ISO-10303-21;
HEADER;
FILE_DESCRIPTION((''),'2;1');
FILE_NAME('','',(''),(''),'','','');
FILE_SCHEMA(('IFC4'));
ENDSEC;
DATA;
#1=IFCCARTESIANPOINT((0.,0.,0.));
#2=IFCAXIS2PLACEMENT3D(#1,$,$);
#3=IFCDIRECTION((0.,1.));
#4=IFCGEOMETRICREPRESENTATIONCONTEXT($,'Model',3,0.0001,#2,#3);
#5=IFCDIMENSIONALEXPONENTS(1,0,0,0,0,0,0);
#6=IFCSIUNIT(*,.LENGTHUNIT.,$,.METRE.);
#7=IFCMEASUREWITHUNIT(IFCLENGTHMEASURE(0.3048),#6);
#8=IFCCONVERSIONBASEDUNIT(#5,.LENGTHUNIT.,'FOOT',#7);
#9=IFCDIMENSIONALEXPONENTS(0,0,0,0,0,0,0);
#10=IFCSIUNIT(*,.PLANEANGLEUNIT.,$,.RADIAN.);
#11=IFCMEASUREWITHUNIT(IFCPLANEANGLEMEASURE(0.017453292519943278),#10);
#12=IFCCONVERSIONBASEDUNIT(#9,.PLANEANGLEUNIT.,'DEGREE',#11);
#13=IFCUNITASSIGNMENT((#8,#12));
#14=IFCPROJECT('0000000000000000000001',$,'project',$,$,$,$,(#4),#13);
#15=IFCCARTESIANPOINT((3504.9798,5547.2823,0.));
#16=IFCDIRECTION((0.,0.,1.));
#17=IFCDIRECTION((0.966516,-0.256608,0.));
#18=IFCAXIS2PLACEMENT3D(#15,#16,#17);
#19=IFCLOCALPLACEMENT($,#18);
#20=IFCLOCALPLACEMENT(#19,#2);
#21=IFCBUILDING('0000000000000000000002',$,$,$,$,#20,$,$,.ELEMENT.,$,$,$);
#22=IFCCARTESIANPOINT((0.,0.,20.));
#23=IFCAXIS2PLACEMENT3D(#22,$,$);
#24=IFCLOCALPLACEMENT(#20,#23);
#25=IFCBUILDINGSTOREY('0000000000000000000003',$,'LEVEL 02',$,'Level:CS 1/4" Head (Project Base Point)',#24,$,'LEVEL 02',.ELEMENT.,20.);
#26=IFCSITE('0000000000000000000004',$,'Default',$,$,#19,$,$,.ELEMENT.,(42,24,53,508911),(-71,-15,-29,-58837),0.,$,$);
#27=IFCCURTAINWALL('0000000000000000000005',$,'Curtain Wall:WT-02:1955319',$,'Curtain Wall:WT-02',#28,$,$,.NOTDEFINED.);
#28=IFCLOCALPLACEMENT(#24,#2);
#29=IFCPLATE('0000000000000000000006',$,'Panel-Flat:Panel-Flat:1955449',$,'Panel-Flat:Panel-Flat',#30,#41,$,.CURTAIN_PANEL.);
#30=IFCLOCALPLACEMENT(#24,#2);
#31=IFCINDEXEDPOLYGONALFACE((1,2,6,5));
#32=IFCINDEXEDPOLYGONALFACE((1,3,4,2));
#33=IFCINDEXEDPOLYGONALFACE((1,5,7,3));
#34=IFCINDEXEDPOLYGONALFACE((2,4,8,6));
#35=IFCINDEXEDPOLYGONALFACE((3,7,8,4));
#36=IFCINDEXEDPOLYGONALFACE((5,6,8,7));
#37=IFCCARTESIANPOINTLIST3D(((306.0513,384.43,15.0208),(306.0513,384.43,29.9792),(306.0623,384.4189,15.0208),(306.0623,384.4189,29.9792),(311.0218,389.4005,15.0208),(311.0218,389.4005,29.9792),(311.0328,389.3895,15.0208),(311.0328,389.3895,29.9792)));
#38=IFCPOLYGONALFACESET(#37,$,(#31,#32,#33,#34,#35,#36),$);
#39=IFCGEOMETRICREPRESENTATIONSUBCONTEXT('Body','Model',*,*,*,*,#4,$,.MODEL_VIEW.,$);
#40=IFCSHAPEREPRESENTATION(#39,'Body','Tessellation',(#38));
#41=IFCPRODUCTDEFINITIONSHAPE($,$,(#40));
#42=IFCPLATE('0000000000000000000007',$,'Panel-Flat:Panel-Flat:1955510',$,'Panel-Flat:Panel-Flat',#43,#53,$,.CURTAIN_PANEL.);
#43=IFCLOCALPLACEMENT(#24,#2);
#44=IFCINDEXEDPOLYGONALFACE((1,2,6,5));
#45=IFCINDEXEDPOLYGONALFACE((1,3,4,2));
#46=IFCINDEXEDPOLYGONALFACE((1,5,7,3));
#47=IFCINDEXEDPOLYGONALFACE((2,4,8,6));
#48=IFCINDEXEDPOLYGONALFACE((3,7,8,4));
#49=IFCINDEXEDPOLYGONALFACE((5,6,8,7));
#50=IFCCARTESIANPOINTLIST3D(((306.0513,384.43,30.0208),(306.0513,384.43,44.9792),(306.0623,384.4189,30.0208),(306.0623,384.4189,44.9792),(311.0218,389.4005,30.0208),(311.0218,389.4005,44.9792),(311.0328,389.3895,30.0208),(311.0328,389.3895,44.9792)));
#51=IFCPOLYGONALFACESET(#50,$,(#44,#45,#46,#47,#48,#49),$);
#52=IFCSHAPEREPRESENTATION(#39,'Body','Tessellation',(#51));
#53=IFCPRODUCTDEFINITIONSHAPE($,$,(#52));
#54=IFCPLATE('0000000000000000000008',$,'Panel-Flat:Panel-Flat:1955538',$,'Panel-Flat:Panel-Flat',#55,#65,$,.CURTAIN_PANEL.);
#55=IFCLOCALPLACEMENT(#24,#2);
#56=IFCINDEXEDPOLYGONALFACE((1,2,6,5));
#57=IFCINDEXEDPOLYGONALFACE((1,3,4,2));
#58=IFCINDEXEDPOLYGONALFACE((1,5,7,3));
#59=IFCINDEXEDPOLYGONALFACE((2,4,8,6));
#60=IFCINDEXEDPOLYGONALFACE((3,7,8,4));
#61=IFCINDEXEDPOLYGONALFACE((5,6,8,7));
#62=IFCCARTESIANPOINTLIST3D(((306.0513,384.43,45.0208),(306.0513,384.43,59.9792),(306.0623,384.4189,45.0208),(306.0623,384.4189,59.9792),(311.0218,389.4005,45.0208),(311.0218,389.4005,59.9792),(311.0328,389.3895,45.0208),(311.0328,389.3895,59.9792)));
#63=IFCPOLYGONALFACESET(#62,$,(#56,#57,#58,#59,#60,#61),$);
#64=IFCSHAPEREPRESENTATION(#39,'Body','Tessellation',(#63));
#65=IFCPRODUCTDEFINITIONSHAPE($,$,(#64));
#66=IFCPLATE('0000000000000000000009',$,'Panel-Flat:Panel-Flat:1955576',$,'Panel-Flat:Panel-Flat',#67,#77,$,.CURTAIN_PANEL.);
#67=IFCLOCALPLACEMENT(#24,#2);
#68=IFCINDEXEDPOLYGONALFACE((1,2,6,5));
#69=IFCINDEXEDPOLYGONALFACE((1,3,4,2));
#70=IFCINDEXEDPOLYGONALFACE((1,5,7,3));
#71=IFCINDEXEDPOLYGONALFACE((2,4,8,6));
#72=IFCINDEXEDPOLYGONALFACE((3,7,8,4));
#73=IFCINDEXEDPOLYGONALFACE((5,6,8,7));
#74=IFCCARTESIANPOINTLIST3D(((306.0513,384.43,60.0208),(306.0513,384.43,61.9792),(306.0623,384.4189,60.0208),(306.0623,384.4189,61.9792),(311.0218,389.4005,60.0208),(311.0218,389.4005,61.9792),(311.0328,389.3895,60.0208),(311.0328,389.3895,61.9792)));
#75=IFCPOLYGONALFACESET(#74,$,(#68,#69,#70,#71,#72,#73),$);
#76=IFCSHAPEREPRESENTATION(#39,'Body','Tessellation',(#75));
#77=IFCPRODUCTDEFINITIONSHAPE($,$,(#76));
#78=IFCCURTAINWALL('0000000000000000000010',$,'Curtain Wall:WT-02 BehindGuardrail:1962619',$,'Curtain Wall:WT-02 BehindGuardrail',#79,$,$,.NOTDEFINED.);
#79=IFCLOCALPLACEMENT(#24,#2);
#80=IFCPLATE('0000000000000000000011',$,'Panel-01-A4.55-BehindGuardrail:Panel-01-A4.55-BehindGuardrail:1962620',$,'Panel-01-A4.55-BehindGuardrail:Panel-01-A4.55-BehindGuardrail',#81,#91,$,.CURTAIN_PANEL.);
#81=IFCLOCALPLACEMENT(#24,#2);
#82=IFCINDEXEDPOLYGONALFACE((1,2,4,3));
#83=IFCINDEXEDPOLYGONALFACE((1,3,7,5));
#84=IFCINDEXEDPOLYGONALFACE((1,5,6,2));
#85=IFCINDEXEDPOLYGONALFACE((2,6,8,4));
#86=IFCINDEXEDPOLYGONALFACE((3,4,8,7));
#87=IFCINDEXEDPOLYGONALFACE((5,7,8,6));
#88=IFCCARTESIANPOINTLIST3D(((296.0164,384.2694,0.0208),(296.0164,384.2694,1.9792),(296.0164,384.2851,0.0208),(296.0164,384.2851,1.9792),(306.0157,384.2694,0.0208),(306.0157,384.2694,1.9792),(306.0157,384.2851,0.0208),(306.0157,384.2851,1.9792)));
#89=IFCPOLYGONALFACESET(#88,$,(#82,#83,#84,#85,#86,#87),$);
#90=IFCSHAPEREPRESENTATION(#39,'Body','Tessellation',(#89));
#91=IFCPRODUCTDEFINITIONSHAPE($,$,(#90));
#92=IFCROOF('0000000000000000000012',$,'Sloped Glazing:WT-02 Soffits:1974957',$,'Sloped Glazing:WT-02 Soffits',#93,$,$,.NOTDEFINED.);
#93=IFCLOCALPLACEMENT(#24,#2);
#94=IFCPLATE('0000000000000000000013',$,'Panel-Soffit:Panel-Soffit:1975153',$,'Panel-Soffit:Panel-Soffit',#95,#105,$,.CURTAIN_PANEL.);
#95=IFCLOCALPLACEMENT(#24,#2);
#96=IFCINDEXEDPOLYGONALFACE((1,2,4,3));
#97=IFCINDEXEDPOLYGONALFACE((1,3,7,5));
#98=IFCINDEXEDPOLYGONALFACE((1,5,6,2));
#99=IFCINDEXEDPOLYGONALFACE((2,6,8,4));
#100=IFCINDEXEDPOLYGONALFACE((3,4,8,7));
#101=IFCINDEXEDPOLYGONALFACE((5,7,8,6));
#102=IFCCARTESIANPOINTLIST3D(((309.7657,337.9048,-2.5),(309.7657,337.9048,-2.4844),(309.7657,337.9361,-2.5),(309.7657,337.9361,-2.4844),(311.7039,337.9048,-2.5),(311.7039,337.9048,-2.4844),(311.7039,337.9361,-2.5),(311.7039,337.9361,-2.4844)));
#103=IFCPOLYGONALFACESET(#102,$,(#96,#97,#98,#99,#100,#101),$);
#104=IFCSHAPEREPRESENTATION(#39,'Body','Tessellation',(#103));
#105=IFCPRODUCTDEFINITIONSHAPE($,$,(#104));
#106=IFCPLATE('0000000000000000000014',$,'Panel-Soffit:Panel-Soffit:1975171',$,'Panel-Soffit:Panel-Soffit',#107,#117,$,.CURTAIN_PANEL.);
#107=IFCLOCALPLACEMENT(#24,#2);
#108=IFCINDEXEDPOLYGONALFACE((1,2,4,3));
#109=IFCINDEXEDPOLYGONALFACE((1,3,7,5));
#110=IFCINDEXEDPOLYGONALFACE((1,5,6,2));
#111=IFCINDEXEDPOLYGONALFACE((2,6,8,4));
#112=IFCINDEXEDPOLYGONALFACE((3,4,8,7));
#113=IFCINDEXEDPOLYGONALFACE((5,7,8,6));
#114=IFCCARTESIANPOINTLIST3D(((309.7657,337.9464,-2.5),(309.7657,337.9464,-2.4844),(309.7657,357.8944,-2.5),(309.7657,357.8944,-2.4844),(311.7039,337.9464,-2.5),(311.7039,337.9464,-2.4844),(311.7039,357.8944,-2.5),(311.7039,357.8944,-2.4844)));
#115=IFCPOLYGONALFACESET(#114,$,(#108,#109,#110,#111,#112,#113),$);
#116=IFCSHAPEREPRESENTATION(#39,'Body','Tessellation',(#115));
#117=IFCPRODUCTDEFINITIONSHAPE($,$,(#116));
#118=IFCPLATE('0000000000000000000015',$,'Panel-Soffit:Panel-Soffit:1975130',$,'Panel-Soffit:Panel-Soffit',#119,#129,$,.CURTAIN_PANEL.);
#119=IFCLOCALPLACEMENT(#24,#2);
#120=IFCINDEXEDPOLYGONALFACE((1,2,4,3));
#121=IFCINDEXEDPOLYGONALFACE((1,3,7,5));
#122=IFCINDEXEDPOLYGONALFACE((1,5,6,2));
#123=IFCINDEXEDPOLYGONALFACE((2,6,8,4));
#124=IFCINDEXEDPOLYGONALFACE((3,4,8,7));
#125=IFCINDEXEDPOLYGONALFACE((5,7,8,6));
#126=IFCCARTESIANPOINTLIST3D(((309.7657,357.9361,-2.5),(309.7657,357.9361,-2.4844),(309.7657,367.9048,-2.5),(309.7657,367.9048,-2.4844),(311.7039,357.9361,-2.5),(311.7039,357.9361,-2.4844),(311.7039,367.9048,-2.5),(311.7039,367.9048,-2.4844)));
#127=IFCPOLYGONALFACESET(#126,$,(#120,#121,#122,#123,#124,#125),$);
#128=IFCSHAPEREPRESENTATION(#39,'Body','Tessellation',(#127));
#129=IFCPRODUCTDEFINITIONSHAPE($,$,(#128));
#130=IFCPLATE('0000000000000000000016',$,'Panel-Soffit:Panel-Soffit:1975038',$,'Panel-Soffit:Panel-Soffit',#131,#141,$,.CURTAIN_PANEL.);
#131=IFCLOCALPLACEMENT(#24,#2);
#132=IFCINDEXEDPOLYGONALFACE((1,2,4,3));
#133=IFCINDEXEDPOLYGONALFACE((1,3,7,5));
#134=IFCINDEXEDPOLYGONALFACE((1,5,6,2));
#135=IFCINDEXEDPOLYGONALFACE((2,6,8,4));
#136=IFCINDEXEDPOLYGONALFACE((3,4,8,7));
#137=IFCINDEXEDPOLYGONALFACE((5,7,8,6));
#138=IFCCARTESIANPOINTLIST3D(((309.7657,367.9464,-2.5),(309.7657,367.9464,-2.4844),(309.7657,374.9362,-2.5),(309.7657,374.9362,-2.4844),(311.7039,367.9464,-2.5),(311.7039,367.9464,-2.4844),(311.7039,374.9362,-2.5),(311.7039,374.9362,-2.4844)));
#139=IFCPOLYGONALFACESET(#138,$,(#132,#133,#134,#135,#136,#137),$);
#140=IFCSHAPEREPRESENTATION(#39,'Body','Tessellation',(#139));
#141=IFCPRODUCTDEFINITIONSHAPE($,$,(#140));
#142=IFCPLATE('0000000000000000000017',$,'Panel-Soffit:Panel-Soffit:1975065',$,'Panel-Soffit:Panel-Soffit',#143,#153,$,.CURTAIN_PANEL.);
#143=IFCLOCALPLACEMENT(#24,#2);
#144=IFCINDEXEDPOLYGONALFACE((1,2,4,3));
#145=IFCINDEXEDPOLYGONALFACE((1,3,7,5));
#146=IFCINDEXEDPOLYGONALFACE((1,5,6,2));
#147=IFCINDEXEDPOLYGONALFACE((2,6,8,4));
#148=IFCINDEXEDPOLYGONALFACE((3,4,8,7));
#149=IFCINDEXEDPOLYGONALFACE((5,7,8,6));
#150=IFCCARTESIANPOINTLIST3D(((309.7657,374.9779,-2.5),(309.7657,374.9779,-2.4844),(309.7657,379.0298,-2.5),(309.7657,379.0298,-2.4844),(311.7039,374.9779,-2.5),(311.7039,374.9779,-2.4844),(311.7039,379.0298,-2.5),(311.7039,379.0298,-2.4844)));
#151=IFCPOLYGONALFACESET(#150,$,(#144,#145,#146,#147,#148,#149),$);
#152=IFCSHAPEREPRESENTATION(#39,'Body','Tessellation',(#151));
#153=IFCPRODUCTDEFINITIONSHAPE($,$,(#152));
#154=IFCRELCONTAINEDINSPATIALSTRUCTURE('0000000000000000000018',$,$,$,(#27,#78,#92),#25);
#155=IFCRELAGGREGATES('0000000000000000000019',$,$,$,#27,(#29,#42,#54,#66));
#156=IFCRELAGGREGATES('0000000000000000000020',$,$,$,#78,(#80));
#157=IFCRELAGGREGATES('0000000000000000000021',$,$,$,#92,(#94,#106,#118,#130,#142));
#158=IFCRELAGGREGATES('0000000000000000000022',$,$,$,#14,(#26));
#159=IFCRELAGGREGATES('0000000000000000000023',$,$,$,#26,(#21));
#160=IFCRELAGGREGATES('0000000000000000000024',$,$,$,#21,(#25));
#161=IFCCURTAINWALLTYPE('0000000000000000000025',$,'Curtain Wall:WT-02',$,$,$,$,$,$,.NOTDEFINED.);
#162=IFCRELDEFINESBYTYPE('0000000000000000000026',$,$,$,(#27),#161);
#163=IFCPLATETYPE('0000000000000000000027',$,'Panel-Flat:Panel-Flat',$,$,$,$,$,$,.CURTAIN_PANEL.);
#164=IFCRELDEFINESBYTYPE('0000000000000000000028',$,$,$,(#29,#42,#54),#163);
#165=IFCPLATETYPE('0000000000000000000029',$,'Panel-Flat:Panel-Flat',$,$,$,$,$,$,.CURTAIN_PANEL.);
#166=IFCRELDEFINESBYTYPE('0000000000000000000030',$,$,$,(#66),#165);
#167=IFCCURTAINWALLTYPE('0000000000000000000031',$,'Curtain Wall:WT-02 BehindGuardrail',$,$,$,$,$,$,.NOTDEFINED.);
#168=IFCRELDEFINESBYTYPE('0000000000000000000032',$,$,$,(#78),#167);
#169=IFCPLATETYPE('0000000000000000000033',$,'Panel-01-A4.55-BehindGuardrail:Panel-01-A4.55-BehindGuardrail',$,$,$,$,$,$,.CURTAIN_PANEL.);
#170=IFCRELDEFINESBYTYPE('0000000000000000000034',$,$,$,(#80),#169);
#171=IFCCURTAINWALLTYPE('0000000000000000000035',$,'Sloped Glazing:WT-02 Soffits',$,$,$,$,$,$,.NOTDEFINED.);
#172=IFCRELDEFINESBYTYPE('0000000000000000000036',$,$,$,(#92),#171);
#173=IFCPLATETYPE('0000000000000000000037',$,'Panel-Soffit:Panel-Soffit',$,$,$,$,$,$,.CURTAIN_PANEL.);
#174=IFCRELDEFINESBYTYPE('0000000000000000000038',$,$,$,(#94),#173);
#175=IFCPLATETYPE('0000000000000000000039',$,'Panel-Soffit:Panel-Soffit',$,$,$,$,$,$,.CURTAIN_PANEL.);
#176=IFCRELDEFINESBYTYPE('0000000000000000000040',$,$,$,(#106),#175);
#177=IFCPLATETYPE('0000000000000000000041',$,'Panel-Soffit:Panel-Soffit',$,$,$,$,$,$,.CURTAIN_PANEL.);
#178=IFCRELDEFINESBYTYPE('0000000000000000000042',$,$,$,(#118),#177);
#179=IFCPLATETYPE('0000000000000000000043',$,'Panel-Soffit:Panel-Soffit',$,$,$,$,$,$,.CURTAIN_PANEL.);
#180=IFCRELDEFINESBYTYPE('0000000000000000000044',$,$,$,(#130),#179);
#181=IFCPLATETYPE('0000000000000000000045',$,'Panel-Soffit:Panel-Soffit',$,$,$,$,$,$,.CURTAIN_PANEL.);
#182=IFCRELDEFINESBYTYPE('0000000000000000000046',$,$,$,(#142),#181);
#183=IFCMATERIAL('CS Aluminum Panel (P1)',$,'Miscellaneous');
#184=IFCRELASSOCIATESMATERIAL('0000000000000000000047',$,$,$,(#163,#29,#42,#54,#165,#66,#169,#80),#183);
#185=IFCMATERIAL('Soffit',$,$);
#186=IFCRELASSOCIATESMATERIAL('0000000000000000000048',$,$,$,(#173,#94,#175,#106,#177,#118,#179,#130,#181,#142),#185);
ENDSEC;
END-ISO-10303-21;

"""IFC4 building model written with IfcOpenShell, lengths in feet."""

from ifc_helpers import new_model, entity, si_unit, converted_unit, direction, frame, origin, place, context, subcontext, project, spatial, indexed_curve, outline, extrude, source, transform, mapped, material, type_object, type_shapes, element, aggregate, save


model = new_model("IFC4")

# Units and contexts
model_context = context("Model", 3, precision=0.0001, world=origin(), true_north=direction((0.0, 1.0)))
body_context = subcontext(model_context, "Body", "Model", "MODEL_VIEW")
ifc_project = project(units=[converted_unit("LENGTHUNIT", "FOOT", entity("IfcLengthMeasure", 0.3048), si_unit("LENGTHUNIT", "METRE"), dimensions=[1, 0, 0, 0, 0, 0, 0]), converted_unit("PLANEANGLEUNIT", "DEGREE", entity("IfcPlaneAngleMeasure", 0.017453292519943278), si_unit("PLANEANGLEUNIT", "RADIAN"), dimensions=[0, 0, 0, 0, 0, 0, 0])], contexts=[model_context])

# Site, building, storey
site_placement = place(None, frame((3504.9798, 5547.2823, 0.0), z_axis=(0.0, 0.0, 1.0), x_axis=(0.966516, -0.256608, 0.0)))
site = spatial("IfcSite", under=ifc_project, at=site_placement, Name="Default", CompositionType="ELEMENT", RefLatitude=(42, 24, 53, 508911), RefLongitude=(-71, -15, -29, -58837), RefElevation=0.0)
building_placement = place(site_placement, origin())
building = spatial("IfcBuilding", under=site, at=building_placement, CompositionType="ELEMENT")
storey_placement = place(building_placement, frame((0.0, 0.0, 20.0)))
storey = spatial("IfcBuildingStorey", under=building, at=storey_placement, Name="LEVEL 02", ObjectType="Level:CS 1/4\" Head (Project Base Point)", LongName="LEVEL 02", CompositionType="ELEMENT", Elevation=20.0)

# Shared definitions
curtain_wall_type_1 = type_object("IfcCurtainWallType", Name="Curtain Wall:WT-02", PredefinedType="NOTDEFINED")
ifc_material_1 = material(Name="CS Aluminum Panel (P1)", Category="Miscellaneous")

# Shared definitions
curtain_wall_type_2 = type_object("IfcCurtainWallType", Name="Sloped Glazing:WT-02 Soffits", PredefinedType="NOTDEFINED")
ifc_material_2 = material(Name="Soffit")

# Curtain wall, plates
curtain_wall_1_placement = place(storey_placement, frame((0.0, 0.0, -20.0)))
curtain_wall_1 = element("IfcCurtainWall", 1, at=curtain_wall_1_placement, inside=storey, type_object=curtain_wall_type_1, Name="Curtain Wall:WT-02:1955319", ObjectType="Curtain Wall:WT-02", PredefinedType="NOTDEFINED")
plate_type_1 = type_object("IfcPlateType", Name="Panel-Flat:Panel-Flat", PredefinedType="CURTAIN_PANEL", material=ifc_material_1)
shared_shape_1 = source(origin(), body_context, "Body", "SweptSolid", [
    extrude(outline(indexed_curve([(-0.0078, -3.5147), (0.0078, -3.5147), (0.0078, 3.5147), (-0.0078, 3.5147), (-0.0078, -3.5147)], self_intersect=False)), frame((3.5147, 0.0078, 0.0), z_axis=(0.0, 0.0, 1.0), x_axis=(0.0, -1.0, 0.0)), (0.0, 0.0, 1.0), 14.9583),
])
type_shapes(plate_type_1, [shared_shape_1])
plate_1_placement = place(curtain_wall_1_placement, frame((306.0623, 384.4189, 35.0208), z_axis=(0.0, 0.0, 1.0), x_axis=(0.707107, 0.707107, 0.0)))
plate_1 = element("IfcPlate", 2, at=plate_1_placement, type_object=plate_type_1, material=ifc_material_1, Name="Panel-Flat:Panel-Flat:1955449", ObjectType="Panel-Flat:Panel-Flat", PredefinedType="CURTAIN_PANEL", context=body_context, shape_type="MappedRepresentation", body=[
    mapped(shared_shape_1, transform((0.0, 0.0, 0.0), scale=1.0)),
])
plate_2_placement = place(curtain_wall_1_placement, frame((306.0623, 384.4189, 50.0208), z_axis=(0.0, 0.0, 1.0), x_axis=(0.707107, 0.707107, 0.0)))
plate_2 = element("IfcPlate", 3, at=plate_2_placement, type_object=plate_type_1, material=ifc_material_1, Name="Panel-Flat:Panel-Flat:1955510", ObjectType="Panel-Flat:Panel-Flat", PredefinedType="CURTAIN_PANEL", context=body_context, shape_type="MappedRepresentation", body=[
    mapped(shared_shape_1, transform((0.0, 0.0, 0.0), scale=1.0)),
])
plate_3_placement = place(curtain_wall_1_placement, frame((306.0623, 384.4189, 65.0208), z_axis=(0.0, 0.0, 1.0), x_axis=(0.707107, 0.707107, 0.0)))
plate_3 = element("IfcPlate", 4, at=plate_3_placement, type_object=plate_type_1, material=ifc_material_1, Name="Panel-Flat:Panel-Flat:1955538", ObjectType="Panel-Flat:Panel-Flat", PredefinedType="CURTAIN_PANEL", context=body_context, shape_type="MappedRepresentation", body=[
    mapped(shared_shape_1, transform((0.0, 0.0, 0.0), scale=1.0)),
])
plate_type_2 = type_object("IfcPlateType", Name="Panel-Flat:Panel-Flat", PredefinedType="CURTAIN_PANEL", material=ifc_material_1)
shared_shape_2 = source(origin(), body_context, "Body", "SweptSolid", [
    extrude(outline(indexed_curve([(-0.0078, -3.5147), (0.0078, -3.5147), (0.0078, 3.5147), (-0.0078, 3.5147), (-0.0078, -3.5147)], self_intersect=False)), frame((3.5147, 0.0078, 0.0), z_axis=(0.0, 0.0, 1.0), x_axis=(0.0, -1.0, 0.0)), (0.0, 0.0, 1.0), 1.9583),
])
type_shapes(plate_type_2, [shared_shape_2])
plate_4_placement = place(curtain_wall_1_placement, frame((306.0623, 384.4189, 80.0208), z_axis=(0.0, 0.0, 1.0), x_axis=(0.707107, 0.707107, 0.0)))
plate_4 = element("IfcPlate", 5, at=plate_4_placement, type_object=plate_type_2, material=ifc_material_1, Name="Panel-Flat:Panel-Flat:1955576", ObjectType="Panel-Flat:Panel-Flat", PredefinedType="CURTAIN_PANEL", context=body_context, shape_type="MappedRepresentation", body=[
    mapped(shared_shape_2, transform((0.0, 0.0, 0.0), scale=1.0)),
])
aggregate(curtain_wall_1, [plate_1, plate_2, plate_3, plate_4])

# Curtain wall, plate
curtain_wall_type_3 = type_object("IfcCurtainWallType", Name="Curtain Wall:WT-02 BehindGuardrail", PredefinedType="NOTDEFINED")
curtain_wall_2_placement = place(storey_placement, frame((0.0, 0.0, -20.0)))
curtain_wall_2 = element("IfcCurtainWall", 6, at=curtain_wall_2_placement, inside=storey, type_object=curtain_wall_type_3, Name="Curtain Wall:WT-02 BehindGuardrail:1962619", ObjectType="Curtain Wall:WT-02 BehindGuardrail", PredefinedType="NOTDEFINED")
plate_type_3 = type_object("IfcPlateType", Name="Panel-01-A4.55-BehindGuardrail:Panel-01-A4.55-BehindGuardrail", PredefinedType="CURTAIN_PANEL", material=ifc_material_1)
shared_shape_3 = source(origin(), body_context, "Body", "SweptSolid", [
    extrude(outline(indexed_curve([(-0.0078, -4.9996), (0.0078, -4.9996), (0.0078, 4.9996), (-0.0078, 4.9996), (-0.0078, -4.9996)], self_intersect=False)), frame((4.9996, 0.0078, 0.0), z_axis=(0.0, 0.0, 1.0), x_axis=(0.0, -1.0, 0.0)), (0.0, 0.0, 1.0), 1.9583),
])
type_shapes(plate_type_3, [shared_shape_3])
plate_5_placement = place(curtain_wall_2_placement, frame((306.0157, 384.2851, 20.0208), z_axis=(0.0, 0.0, 1.0), x_axis=(-1.0, 0.0, 0.0)))
plate_5 = element("IfcPlate", 7, at=plate_5_placement, type_object=plate_type_3, material=ifc_material_1, Name="Panel-01-A4.55-BehindGuardrail:Panel-01-A4.55-BehindGuardrail:1962620", ObjectType="Panel-01-A4.55-BehindGuardrail:Panel-01-A4.55-BehindGuardrail", PredefinedType="CURTAIN_PANEL", context=body_context, shape_type="MappedRepresentation", body=[
    mapped(shared_shape_3, transform((0.0, 0.0, 0.0), scale=1.0)),
])
aggregate(curtain_wall_2, [plate_5])

# Roof, plates
roof_1_placement = place(storey_placement, frame((0.0, 0.0, -20.0)))
roof_1 = element("IfcRoof", 8, at=roof_1_placement, inside=storey, type_object=curtain_wall_type_2, Name="Sloped Glazing:WT-02 Soffits:1974957", ObjectType="Sloped Glazing:WT-02 Soffits", PredefinedType="NOTDEFINED")
plate_type_4 = type_object("IfcPlateType", Name="Panel-Soffit:Panel-Soffit", PredefinedType="CURTAIN_PANEL", material=ifc_material_2)
shared_shape_4 = source(origin(), body_context, "Body", "SweptSolid", [
    extrude(outline(indexed_curve([(-0.0078, -0.9691), (0.0078, -0.9691), (0.0078, 0.9691), (-0.0078, 0.9691), (-0.0078, -0.9691)], self_intersect=False)), frame((0.0, -0.0078, -0.0105), z_axis=(0.0, 0.0, 1.0), x_axis=(0.0, -1.0, 0.0)), (0.0, 0.0, 1.0), 0.0313),
])
type_shapes(plate_type_4, [shared_shape_4])
plate_6_placement = place(roof_1_placement, frame((310.7348, 337.9153, 17.5), z_axis=(0.0, 1.0, 0.0), x_axis=(1.0, 0.0, 0.0)))
plate_6 = element("IfcPlate", 9, at=plate_6_placement, type_object=plate_type_4, material=ifc_material_2, Name="Panel-Soffit:Panel-Soffit:1975153", ObjectType="Panel-Soffit:Panel-Soffit", PredefinedType="CURTAIN_PANEL", context=body_context, shape_type="MappedRepresentation", body=[
    mapped(shared_shape_4, transform((0.0, 0.0, 0.0), scale=1.0)),
])
plate_type_5 = type_object("IfcPlateType", Name="Panel-Soffit:Panel-Soffit", PredefinedType="CURTAIN_PANEL", material=ifc_material_2)
shared_shape_5 = source(origin(), body_context, "Body", "SweptSolid", [
    extrude(outline(indexed_curve([(-0.0078, -0.9691), (0.0078, -0.9691), (0.0078, 0.9691), (-0.0078, 0.9691), (-0.0078, -0.9691)], self_intersect=False)), frame((0.9691, 0.0078, 0.0), z_axis=(0.0, 0.0, 1.0), x_axis=(0.0, -1.0, 0.0)), (0.0, 0.0, 1.0), 19.948),
])
type_shapes(plate_type_5, [shared_shape_5])
plate_7_placement = place(roof_1_placement, frame((309.7657, 337.9464, 17.5156), z_axis=(0.0, 1.0, 0.0), x_axis=(1.0, 0.0, 0.0)))
plate_7 = element("IfcPlate", 10, at=plate_7_placement, type_object=plate_type_5, material=ifc_material_2, Name="Panel-Soffit:Panel-Soffit:1975171", ObjectType="Panel-Soffit:Panel-Soffit", PredefinedType="CURTAIN_PANEL", context=body_context, shape_type="MappedRepresentation", body=[
    mapped(shared_shape_5, transform((0.0, 0.0, 0.0), scale=1.0)),
])
plate_type_6 = type_object("IfcPlateType", Name="Panel-Soffit:Panel-Soffit", PredefinedType="CURTAIN_PANEL", material=ifc_material_2)
shared_shape_6 = source(origin(), body_context, "Body", "SweptSolid", [
    extrude(outline(indexed_curve([(-0.0078, -0.9691), (0.0078, -0.9691), (0.0078, 0.9691), (-0.0078, 0.9691), (-0.0078, -0.9691)], self_intersect=False)), frame((0.9691, 0.0078, 0.0), z_axis=(0.0, 0.0, 1.0), x_axis=(0.0, -1.0, 0.0)), (0.0, 0.0, 1.0), 9.9687),
])
type_shapes(plate_type_6, [shared_shape_6])
plate_8_placement = place(roof_1_placement, frame((309.7657, 357.9361, 17.5156), z_axis=(0.0, 1.0, 0.0), x_axis=(1.0, 0.0, 0.0)))
plate_8 = element("IfcPlate", 11, at=plate_8_placement, type_object=plate_type_6, material=ifc_material_2, Name="Panel-Soffit:Panel-Soffit:1975130", ObjectType="Panel-Soffit:Panel-Soffit", PredefinedType="CURTAIN_PANEL", context=body_context, shape_type="MappedRepresentation", body=[
    mapped(shared_shape_6, transform((0.0, 0.0, 0.0), scale=1.0)),
])
plate_type_7 = type_object("IfcPlateType", Name="Panel-Soffit:Panel-Soffit", PredefinedType="CURTAIN_PANEL", material=ifc_material_2)
shared_shape_7 = source(origin(), body_context, "Body", "SweptSolid", [
    extrude(outline(indexed_curve([(-0.0078, -0.9691), (0.0078, -0.9691), (0.0078, 0.9691), (-0.0078, 0.9691), (-0.0078, -0.9691)], self_intersect=False)), frame((0.9691, 0.0078, 0.0), z_axis=(0.0, 0.0, 1.0), x_axis=(0.0, -1.0, 0.0)), (0.0, 0.0, 1.0), 6.9898),
])
type_shapes(plate_type_7, [shared_shape_7])
plate_9_placement = place(roof_1_placement, frame((309.7657, 367.9464, 17.5156), z_axis=(0.0, 1.0, 0.0), x_axis=(1.0, 0.0, 0.0)))
plate_9 = element("IfcPlate", 12, at=plate_9_placement, type_object=plate_type_7, material=ifc_material_2, Name="Panel-Soffit:Panel-Soffit:1975038", ObjectType="Panel-Soffit:Panel-Soffit", PredefinedType="CURTAIN_PANEL", context=body_context, shape_type="MappedRepresentation", body=[
    mapped(shared_shape_7, transform((0.0, 0.0, 0.0), scale=1.0)),
])
plate_type_8 = type_object("IfcPlateType", Name="Panel-Soffit:Panel-Soffit", PredefinedType="CURTAIN_PANEL", material=ifc_material_2)
shared_shape_8 = source(origin(), body_context, "Body", "SweptSolid", [
    extrude(outline(indexed_curve([(-0.0078, -0.9691), (0.0078, -0.9691), (0.0078, 0.9691), (-0.0078, 0.9691), (-0.0078, -0.9691)], self_intersect=False)), frame((0.9691, 0.0078, 0.0), z_axis=(0.0, 0.0, 1.0), x_axis=(0.0, -1.0, 0.0)), (0.0, 0.0, 1.0), 4.052),
])
type_shapes(plate_type_8, [shared_shape_8])
plate_10_placement = place(roof_1_placement, frame((309.7657, 374.9779, 17.5156), z_axis=(0.0, 1.0, 0.0), x_axis=(1.0, 0.0, 0.0)))
plate_10 = element("IfcPlate", 13, at=plate_10_placement, type_object=plate_type_8, material=ifc_material_2, Name="Panel-Soffit:Panel-Soffit:1975065", ObjectType="Panel-Soffit:Panel-Soffit", PredefinedType="CURTAIN_PANEL", context=body_context, shape_type="MappedRepresentation", body=[
    mapped(shared_shape_8, transform((0.0, 0.0, 0.0), scale=1.0)),
])
aggregate(roof_1, [plate_6, plate_7, plate_8, plate_9, plate_10])

save(model, "model.ifc")
